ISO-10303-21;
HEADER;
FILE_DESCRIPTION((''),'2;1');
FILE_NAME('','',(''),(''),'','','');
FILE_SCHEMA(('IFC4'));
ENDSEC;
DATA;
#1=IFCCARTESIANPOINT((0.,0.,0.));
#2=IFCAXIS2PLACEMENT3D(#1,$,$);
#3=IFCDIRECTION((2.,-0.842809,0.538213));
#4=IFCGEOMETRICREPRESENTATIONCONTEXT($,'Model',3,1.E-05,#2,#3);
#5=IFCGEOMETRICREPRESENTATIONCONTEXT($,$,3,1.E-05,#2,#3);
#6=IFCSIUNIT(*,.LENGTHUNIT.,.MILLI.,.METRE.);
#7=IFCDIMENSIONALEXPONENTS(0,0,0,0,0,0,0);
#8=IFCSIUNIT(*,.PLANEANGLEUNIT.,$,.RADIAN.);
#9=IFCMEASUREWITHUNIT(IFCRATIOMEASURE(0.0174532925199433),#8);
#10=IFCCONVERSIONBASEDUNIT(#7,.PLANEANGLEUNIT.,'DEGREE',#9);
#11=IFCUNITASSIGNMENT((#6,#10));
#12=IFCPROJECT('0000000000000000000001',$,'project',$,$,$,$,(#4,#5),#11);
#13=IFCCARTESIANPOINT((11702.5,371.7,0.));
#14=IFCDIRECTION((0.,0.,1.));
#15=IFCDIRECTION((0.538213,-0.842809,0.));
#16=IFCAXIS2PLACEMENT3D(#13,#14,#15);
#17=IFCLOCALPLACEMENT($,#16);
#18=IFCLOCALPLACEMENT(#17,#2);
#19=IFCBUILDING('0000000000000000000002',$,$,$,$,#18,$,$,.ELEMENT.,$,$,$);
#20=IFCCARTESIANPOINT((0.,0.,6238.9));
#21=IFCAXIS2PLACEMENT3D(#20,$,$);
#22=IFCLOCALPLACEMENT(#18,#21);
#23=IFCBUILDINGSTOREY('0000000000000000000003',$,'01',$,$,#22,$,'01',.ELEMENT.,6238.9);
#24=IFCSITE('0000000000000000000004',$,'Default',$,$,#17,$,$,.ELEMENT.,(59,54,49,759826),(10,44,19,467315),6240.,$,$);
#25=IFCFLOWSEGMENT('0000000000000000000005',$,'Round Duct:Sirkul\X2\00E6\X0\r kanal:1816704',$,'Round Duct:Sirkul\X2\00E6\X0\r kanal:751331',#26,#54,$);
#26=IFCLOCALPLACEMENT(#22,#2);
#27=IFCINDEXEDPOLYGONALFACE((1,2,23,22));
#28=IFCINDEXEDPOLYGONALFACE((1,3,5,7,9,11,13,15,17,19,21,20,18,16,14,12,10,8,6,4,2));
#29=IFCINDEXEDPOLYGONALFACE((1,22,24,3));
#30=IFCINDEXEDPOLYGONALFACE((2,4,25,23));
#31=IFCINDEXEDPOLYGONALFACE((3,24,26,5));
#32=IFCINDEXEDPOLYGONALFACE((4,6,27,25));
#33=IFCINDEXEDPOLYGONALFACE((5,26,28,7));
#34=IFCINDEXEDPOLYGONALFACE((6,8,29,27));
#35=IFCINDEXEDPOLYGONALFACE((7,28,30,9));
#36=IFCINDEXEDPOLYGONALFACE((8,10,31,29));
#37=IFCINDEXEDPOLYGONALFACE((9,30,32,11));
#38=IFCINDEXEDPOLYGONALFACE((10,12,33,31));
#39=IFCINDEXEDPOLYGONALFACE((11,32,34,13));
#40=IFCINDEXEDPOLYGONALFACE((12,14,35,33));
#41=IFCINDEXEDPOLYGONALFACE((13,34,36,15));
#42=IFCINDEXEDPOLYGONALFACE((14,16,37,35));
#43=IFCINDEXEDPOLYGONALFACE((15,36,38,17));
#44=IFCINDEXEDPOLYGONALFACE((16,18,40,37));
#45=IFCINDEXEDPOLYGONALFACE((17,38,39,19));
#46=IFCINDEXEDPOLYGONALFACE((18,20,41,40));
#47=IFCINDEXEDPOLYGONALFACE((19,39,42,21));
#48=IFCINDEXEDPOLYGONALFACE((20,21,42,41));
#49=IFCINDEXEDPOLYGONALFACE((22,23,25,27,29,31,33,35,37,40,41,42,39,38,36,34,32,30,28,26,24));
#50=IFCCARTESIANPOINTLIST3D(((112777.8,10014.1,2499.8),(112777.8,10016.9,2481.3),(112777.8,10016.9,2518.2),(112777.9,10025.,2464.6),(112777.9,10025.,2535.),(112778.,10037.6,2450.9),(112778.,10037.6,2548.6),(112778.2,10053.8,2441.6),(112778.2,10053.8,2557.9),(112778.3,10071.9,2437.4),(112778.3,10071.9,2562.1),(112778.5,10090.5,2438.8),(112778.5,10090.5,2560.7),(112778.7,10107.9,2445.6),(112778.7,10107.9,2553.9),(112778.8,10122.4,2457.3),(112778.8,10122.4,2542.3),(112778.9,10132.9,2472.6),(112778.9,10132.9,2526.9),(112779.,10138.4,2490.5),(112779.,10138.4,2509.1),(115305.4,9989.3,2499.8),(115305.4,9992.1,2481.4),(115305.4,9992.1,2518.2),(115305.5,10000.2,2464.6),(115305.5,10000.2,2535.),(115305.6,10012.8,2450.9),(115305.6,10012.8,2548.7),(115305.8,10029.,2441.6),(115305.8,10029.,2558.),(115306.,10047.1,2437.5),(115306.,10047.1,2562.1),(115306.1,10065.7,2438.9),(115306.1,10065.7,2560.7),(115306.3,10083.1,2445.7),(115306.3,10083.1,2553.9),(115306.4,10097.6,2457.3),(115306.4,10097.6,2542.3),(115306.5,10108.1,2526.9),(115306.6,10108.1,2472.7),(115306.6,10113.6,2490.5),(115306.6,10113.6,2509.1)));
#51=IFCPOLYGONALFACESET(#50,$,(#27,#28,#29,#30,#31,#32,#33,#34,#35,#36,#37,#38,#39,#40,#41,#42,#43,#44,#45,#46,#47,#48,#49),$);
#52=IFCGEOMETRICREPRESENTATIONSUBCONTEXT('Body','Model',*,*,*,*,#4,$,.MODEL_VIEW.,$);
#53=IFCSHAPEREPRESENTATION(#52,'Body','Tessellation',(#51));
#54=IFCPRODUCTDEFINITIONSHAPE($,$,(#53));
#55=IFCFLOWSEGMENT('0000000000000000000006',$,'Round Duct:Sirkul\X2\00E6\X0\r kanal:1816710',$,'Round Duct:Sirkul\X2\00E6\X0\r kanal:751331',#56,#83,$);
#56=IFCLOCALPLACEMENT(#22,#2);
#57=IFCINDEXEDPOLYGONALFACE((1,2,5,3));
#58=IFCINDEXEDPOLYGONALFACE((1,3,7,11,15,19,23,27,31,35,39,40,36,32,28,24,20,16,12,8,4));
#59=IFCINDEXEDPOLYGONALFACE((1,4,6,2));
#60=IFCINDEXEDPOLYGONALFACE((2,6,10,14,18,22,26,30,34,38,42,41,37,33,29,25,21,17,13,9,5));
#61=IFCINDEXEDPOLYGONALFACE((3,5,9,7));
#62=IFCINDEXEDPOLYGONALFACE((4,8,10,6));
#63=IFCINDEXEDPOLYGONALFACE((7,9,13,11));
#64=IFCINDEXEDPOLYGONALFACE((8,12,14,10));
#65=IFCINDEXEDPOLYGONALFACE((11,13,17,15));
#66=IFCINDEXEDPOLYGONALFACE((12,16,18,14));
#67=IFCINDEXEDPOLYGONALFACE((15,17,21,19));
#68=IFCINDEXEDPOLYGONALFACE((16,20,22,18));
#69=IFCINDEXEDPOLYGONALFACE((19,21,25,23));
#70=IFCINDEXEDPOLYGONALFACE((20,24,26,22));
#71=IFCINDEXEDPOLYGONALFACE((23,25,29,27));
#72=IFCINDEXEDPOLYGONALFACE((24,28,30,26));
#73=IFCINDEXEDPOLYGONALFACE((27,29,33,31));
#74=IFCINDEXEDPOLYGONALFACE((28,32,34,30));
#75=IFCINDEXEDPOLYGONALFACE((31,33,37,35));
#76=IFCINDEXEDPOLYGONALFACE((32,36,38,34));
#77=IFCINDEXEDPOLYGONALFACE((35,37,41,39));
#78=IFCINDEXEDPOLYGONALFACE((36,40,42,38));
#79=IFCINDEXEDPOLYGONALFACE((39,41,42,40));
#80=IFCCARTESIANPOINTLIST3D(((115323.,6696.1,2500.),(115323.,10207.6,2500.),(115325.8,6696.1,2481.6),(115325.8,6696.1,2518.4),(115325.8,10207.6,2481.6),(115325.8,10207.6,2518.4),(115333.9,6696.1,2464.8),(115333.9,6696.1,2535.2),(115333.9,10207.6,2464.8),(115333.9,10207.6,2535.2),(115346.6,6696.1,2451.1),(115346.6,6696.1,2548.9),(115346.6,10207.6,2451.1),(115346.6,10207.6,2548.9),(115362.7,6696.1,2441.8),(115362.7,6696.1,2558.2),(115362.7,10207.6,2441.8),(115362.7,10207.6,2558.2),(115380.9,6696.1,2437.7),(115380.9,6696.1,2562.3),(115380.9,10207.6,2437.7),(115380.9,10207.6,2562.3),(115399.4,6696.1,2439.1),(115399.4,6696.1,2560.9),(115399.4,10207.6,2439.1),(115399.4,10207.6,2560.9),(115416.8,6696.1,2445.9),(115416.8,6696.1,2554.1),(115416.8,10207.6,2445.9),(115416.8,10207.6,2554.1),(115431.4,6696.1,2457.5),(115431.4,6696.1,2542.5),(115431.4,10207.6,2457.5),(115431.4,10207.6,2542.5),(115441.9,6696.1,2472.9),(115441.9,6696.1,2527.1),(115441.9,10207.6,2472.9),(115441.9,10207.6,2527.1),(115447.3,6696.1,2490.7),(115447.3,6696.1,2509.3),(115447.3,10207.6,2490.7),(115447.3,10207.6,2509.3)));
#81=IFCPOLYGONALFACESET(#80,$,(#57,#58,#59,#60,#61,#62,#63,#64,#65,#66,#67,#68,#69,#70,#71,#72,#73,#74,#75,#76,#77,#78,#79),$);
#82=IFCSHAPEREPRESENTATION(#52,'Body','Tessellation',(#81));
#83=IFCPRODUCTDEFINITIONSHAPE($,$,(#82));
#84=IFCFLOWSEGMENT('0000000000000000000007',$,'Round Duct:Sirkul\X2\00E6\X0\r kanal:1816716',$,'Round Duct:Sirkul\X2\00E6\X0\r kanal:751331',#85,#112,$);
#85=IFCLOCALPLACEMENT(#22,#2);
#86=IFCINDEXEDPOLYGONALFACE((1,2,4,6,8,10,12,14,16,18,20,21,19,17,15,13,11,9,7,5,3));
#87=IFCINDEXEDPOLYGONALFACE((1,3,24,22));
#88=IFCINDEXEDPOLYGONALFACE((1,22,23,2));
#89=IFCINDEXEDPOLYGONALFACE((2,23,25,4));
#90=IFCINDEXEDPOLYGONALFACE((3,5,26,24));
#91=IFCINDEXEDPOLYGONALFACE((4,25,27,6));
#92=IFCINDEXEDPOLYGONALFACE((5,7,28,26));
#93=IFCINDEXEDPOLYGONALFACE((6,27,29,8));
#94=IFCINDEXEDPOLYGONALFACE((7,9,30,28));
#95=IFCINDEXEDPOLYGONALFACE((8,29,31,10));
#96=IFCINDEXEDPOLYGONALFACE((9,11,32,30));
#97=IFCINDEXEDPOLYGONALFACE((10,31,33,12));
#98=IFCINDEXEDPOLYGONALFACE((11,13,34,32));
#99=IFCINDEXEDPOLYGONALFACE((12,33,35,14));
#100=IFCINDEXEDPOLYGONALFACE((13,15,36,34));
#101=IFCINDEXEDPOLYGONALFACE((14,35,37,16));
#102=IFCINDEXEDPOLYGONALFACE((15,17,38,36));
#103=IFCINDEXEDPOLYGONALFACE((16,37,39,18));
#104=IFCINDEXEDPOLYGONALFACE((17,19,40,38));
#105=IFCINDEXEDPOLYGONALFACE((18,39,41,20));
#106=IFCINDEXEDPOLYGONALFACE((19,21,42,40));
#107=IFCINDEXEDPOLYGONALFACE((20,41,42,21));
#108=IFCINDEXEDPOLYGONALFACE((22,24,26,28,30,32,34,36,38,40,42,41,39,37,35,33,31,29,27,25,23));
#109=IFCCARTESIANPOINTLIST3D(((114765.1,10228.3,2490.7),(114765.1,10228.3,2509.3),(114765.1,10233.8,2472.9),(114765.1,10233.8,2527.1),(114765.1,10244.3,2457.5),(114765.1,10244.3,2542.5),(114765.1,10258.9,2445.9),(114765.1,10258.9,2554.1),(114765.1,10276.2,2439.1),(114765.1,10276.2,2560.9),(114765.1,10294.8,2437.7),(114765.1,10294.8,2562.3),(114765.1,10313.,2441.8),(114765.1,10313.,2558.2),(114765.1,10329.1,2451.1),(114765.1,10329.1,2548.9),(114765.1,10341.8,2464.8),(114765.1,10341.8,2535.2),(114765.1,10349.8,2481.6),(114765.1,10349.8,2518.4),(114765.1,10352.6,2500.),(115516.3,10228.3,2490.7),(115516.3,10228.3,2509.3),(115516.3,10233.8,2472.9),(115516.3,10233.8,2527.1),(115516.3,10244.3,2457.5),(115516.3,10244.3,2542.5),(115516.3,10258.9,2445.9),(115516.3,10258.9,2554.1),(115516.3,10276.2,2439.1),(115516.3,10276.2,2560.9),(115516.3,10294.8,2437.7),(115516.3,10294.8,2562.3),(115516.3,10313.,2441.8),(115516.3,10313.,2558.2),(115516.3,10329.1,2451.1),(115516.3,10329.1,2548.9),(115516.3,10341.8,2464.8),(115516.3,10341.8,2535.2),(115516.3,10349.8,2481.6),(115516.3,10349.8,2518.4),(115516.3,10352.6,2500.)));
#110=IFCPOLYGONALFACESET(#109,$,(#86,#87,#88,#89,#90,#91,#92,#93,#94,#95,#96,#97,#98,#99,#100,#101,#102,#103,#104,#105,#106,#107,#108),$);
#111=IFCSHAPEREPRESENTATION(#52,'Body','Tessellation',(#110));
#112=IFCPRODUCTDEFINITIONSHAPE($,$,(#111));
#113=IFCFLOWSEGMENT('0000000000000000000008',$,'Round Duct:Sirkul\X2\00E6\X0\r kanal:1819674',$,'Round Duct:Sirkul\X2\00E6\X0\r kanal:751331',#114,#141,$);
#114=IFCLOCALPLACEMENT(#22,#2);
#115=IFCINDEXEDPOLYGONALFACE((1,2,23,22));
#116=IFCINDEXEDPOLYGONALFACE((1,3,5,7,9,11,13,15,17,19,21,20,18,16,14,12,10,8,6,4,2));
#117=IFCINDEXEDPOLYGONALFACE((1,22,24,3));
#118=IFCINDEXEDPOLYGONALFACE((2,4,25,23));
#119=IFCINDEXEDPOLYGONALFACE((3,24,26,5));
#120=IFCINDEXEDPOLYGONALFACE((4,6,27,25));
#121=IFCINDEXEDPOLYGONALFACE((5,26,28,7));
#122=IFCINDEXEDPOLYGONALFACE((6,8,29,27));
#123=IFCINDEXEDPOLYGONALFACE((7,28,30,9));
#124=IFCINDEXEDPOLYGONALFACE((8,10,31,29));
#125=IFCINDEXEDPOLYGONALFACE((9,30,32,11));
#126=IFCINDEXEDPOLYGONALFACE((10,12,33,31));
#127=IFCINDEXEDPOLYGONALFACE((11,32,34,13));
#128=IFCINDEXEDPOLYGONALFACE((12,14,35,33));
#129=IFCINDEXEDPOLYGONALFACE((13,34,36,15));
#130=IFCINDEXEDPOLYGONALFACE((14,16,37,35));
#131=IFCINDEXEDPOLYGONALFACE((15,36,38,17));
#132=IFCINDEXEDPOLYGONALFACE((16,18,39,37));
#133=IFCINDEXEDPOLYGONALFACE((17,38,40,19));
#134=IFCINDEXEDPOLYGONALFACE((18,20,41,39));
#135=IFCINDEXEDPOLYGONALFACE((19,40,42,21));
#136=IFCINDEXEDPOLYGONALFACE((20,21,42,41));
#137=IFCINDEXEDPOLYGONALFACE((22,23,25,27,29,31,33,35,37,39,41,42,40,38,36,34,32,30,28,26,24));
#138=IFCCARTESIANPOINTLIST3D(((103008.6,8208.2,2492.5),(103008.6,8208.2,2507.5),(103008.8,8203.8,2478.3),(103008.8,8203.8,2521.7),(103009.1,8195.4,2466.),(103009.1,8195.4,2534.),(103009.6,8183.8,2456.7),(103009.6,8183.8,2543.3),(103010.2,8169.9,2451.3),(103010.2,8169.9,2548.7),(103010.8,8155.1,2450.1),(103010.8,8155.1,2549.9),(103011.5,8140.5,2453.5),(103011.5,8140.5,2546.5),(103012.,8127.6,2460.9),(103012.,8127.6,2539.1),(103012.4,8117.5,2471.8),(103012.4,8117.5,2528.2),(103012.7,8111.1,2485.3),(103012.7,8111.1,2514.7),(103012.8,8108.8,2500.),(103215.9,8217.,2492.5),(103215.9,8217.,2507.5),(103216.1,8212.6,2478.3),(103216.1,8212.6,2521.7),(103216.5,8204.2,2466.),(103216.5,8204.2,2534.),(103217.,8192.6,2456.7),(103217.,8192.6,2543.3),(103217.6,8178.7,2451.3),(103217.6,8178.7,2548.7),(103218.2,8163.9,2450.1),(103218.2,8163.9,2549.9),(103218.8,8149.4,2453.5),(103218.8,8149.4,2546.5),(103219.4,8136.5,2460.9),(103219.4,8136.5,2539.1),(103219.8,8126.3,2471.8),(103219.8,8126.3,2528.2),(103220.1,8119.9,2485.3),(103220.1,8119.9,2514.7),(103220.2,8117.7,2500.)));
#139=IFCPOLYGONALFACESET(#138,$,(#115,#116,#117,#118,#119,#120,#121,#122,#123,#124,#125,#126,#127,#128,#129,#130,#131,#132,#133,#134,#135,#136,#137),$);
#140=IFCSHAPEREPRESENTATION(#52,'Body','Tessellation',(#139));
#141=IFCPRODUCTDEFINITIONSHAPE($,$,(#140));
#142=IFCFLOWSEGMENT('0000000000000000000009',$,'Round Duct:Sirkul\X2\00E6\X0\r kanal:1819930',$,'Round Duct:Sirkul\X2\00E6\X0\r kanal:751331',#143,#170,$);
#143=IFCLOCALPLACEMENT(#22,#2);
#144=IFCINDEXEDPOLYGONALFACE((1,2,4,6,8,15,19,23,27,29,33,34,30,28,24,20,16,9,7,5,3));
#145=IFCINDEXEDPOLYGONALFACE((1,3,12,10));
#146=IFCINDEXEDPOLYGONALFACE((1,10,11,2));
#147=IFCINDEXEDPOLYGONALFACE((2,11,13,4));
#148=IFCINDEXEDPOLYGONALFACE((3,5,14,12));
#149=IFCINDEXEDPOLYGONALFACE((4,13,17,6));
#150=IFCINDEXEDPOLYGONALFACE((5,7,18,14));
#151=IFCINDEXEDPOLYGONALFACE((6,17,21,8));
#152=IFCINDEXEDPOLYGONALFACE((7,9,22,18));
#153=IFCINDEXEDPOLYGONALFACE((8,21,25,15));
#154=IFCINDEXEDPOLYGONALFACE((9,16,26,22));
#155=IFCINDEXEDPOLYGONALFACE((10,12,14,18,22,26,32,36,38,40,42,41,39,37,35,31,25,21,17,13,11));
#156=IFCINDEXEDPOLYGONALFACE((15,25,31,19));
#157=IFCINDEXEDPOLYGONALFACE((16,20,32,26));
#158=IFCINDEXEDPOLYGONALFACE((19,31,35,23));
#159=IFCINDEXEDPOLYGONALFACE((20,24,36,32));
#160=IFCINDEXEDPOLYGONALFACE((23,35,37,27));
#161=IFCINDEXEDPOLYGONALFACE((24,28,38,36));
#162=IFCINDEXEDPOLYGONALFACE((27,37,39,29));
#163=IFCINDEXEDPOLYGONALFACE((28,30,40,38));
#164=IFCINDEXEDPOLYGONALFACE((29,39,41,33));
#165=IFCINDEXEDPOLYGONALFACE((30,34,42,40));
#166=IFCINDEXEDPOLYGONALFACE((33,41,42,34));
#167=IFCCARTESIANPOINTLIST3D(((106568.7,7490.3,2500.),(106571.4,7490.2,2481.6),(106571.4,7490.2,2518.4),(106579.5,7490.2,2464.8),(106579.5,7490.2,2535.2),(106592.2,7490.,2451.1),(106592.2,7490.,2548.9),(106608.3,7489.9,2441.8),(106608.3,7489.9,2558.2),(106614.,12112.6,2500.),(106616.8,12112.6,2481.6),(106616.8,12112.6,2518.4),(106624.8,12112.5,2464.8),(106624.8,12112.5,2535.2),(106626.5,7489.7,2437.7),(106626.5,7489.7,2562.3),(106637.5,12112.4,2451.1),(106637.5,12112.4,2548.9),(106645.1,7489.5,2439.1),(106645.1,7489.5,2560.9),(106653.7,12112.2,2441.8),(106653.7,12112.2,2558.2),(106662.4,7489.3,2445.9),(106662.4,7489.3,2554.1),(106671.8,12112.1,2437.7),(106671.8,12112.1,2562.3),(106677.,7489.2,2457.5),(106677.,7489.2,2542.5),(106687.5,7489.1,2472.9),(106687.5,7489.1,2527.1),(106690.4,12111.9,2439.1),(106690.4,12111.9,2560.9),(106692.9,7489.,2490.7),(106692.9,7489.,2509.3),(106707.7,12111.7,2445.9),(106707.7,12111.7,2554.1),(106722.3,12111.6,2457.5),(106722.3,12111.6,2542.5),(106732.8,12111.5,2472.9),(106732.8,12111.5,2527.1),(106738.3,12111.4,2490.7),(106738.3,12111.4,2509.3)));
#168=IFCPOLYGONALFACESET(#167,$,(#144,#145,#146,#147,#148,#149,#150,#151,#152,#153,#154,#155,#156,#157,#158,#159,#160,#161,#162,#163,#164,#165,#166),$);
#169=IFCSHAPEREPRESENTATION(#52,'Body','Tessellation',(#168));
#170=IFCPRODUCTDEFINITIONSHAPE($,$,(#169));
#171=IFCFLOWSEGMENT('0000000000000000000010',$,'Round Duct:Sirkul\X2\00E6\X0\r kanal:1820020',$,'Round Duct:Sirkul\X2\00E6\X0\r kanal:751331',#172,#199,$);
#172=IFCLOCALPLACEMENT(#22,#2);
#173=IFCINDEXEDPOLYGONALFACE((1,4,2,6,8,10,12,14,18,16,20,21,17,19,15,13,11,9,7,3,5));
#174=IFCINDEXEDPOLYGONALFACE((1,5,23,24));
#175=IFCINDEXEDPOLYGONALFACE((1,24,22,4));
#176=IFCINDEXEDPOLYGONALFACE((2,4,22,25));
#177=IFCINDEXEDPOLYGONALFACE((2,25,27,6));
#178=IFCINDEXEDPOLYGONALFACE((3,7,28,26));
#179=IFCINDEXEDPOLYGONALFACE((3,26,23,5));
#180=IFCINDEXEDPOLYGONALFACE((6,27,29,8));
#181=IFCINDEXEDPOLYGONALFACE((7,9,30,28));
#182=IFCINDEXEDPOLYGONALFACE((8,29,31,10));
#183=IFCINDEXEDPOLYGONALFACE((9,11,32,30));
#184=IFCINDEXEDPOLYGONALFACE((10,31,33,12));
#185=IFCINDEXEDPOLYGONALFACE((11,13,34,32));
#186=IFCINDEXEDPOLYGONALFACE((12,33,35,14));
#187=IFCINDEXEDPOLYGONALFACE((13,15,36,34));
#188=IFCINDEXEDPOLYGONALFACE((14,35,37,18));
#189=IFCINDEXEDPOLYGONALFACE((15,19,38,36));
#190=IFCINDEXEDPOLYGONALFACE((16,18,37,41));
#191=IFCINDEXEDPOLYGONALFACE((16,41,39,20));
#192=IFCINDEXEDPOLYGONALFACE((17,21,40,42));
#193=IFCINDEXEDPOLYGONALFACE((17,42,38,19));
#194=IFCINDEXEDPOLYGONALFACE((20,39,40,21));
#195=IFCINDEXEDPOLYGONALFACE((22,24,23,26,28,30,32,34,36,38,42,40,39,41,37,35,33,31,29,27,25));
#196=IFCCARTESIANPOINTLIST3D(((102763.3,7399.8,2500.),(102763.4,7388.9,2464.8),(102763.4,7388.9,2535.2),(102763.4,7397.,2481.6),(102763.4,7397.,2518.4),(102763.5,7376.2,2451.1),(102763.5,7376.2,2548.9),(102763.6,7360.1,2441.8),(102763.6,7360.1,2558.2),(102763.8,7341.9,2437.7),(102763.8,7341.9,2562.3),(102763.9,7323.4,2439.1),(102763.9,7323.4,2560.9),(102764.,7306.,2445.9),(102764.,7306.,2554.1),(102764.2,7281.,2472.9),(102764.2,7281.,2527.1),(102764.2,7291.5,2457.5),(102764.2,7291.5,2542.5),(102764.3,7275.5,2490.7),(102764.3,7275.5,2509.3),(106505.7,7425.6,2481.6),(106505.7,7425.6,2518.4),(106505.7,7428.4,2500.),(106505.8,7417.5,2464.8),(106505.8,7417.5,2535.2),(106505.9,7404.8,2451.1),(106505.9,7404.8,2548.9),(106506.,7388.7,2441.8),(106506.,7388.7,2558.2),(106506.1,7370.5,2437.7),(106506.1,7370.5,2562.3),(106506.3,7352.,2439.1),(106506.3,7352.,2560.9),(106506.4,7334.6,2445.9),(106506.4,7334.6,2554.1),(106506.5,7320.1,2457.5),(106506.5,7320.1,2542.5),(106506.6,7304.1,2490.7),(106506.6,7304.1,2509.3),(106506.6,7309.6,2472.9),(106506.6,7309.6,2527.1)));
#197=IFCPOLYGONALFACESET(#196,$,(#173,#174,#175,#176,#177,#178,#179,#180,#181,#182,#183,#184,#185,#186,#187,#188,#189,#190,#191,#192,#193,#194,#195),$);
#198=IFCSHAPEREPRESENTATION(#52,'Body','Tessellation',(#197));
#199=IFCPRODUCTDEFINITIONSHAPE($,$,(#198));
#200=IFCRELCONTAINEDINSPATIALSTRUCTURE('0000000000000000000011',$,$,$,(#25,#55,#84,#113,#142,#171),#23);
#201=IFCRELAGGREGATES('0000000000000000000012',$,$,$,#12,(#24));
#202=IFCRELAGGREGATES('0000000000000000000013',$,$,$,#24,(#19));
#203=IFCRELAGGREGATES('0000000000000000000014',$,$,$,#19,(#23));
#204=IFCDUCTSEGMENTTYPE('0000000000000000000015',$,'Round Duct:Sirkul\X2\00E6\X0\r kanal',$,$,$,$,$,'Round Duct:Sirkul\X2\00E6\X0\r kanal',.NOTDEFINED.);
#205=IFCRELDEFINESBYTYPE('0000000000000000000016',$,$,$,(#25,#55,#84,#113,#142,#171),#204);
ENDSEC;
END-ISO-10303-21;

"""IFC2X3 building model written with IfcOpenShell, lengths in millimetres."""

from ifc_helpers import new_model, entity, si_unit, converted_unit, direction, frame, frame_2d, origin, origin_2d_with_axis, place, context, subcontext, project, spatial, circle, extrude, type_object, element, save


model = new_model("IFC2X3")

# Units and contexts
model_context = context("Model", 3, precision=1e-05, world=origin(), true_north=direction((2.0, -0.842809, 0.538213)))
context_of_model = context(None, 3, precision=1e-05, world=origin(), true_north=direction((2.0, -0.842809, 0.538213)))
body_context = subcontext(model_context, "Body", "Model", "MODEL_VIEW")
ifc_project = project(units=[si_unit("LENGTHUNIT", "METRE", prefix="MILLI"), converted_unit("PLANEANGLEUNIT", "DEGREE", entity("IfcRatioMeasure", 0.0174532925199433), si_unit("PLANEANGLEUNIT", "RADIAN"), dimensions=[0, 0, 0, 0, 0, 0, 0])], contexts=[model_context, context_of_model])

# Site, building, storey
site_placement = place(None, frame((11702.5, 371.7, 0.0), z_axis=(0.0, 0.0, 1.0), x_axis=(0.538213, -0.842809, 0.0)))
site = spatial("IfcSite", under=ifc_project, at=site_placement, Name="Default", CompositionType="ELEMENT", RefLatitude=(59, 54, 49, 759826), RefLongitude=(10, 44, 19, 467315), RefElevation=6240.0)
building_placement = place(site_placement, origin())
building = spatial("IfcBuilding", under=site, at=building_placement, CompositionType="ELEMENT")
storey_placement = place(building_placement, frame((0.0, 0.0, 6238.9)))
storey = spatial("IfcBuildingStorey", under=building, at=storey_placement, Name="01", LongName="01", CompositionType="ELEMENT", Elevation=6238.9)

# Flow segments
duct_segment_type = type_object("IfcDuctSegmentType", Name="Round Duct:Sirkulær kanal", ElementType="Round Duct:Sirkulær kanal", PredefinedType="NOTDEFINED")
flow_segment_1_placement = place(storey_placement, origin())
element("IfcFlowSegment", 1, at=flow_segment_1_placement, inside=storey, type_object=duct_segment_type, Name="Round Duct:Sirkulær kanal:1816704", ObjectType="Round Duct:Sirkulær kanal:751331", context=body_context, shape_type="SweptSolid", body=[
    extrude(circle(Radius=62.5, at=frame_2d((0.0, 0.0), x_axis=(1.0, 0.0))), frame((115306.0, 10051.8, 2499.8), z_axis=(-0.999952, 0.00981, -0.000017), x_axis=(-0.00981, -0.999952, 0.0)), (0.0, 0.0, 1.0), 2527.7),
])
flow_segment_2_placement = place(storey_placement, origin())
element("IfcFlowSegment", 2, at=flow_segment_2_placement, inside=storey, type_object=duct_segment_type, Name="Round Duct:Sirkulær kanal:1816710", ObjectType="Round Duct:Sirkulær kanal:751331", context=body_context, shape_type="SweptSolid", body=[
    extrude(circle(Radius=62.5, at=frame_2d((0.0, 0.0), x_axis=(1.0, 0.0))), frame((115385.5, 6696.1, 2500.0), z_axis=(0.0, 1.0, 0.0), x_axis=(-1.0, 0.0, 0.0)), (0.0, 0.0, 1.0), 3511.5),
])
flow_segment_3_placement = place(storey_placement, origin())
element("IfcFlowSegment", 3, at=flow_segment_3_placement, inside=storey, type_object=duct_segment_type, Name="Round Duct:Sirkulær kanal:1816716", ObjectType="Round Duct:Sirkulær kanal:751331", context=body_context, shape_type="SweptSolid", body=[
    extrude(circle(Radius=62.5, at=frame_2d((0.0, 0.0), x_axis=(1.0, 0.0))), frame((114765.1, 10290.1, 2500.0), z_axis=(1.0, 0.0, 0.0), x_axis=(0.0, 1.0, 0.0)), (0.0, 0.0, 1.0), 751.2),
])
flow_segment_4_placement = place(storey_placement, origin())
element("IfcFlowSegment", 4, at=flow_segment_4_placement, inside=storey, type_object=duct_segment_type, Name="Round Duct:Sirkulær kanal:1819674", ObjectType="Round Duct:Sirkulær kanal:751331", context=body_context, shape_type="SweptSolid", body=[
    extrude(circle(Radius=50.0, at=origin_2d_with_axis()), frame((103010.7, 8158.8, 2500.0), z_axis=(0.999095, 0.042537, 0.0), x_axis=(0.042537, -0.999095, 0.0)), (0.0, 0.0, 1.0), 207.5),
])
flow_segment_5_placement = place(storey_placement, origin())
element("IfcFlowSegment", 5, at=flow_segment_5_placement, inside=storey, type_object=duct_segment_type, Name="Round Duct:Sirkulær kanal:1819930", ObjectType="Round Duct:Sirkulær kanal:751331", context=body_context, shape_type="SweptSolid", body=[
    extrude(circle(Radius=62.5, at=origin_2d_with_axis()), frame((106631.1, 7489.6, 2500.0), z_axis=(0.009807, 0.999952, 0.0), x_axis=(-0.999952, 0.009807, 0.0)), (0.0, 0.0, 1.0), 4622.6),
])
flow_segment_6_placement = place(storey_placement, origin())
element("IfcFlowSegment", 6, at=flow_segment_6_placement, inside=storey, type_object=duct_segment_type, Name="Round Duct:Sirkulær kanal:1820020", ObjectType="Round Duct:Sirkulær kanal:751331", context=body_context, shape_type="SweptSolid", body=[
    extrude(circle(Radius=62.5, at=origin_2d_with_axis()), frame((102763.8, 7337.3, 2500.0), z_axis=(0.999971, 0.007643, 0.0), x_axis=(-0.007643, 0.999971, 0.0)), (0.0, 0.0, 1.0), 3742.5),
])

save(model, "model.ifc")
